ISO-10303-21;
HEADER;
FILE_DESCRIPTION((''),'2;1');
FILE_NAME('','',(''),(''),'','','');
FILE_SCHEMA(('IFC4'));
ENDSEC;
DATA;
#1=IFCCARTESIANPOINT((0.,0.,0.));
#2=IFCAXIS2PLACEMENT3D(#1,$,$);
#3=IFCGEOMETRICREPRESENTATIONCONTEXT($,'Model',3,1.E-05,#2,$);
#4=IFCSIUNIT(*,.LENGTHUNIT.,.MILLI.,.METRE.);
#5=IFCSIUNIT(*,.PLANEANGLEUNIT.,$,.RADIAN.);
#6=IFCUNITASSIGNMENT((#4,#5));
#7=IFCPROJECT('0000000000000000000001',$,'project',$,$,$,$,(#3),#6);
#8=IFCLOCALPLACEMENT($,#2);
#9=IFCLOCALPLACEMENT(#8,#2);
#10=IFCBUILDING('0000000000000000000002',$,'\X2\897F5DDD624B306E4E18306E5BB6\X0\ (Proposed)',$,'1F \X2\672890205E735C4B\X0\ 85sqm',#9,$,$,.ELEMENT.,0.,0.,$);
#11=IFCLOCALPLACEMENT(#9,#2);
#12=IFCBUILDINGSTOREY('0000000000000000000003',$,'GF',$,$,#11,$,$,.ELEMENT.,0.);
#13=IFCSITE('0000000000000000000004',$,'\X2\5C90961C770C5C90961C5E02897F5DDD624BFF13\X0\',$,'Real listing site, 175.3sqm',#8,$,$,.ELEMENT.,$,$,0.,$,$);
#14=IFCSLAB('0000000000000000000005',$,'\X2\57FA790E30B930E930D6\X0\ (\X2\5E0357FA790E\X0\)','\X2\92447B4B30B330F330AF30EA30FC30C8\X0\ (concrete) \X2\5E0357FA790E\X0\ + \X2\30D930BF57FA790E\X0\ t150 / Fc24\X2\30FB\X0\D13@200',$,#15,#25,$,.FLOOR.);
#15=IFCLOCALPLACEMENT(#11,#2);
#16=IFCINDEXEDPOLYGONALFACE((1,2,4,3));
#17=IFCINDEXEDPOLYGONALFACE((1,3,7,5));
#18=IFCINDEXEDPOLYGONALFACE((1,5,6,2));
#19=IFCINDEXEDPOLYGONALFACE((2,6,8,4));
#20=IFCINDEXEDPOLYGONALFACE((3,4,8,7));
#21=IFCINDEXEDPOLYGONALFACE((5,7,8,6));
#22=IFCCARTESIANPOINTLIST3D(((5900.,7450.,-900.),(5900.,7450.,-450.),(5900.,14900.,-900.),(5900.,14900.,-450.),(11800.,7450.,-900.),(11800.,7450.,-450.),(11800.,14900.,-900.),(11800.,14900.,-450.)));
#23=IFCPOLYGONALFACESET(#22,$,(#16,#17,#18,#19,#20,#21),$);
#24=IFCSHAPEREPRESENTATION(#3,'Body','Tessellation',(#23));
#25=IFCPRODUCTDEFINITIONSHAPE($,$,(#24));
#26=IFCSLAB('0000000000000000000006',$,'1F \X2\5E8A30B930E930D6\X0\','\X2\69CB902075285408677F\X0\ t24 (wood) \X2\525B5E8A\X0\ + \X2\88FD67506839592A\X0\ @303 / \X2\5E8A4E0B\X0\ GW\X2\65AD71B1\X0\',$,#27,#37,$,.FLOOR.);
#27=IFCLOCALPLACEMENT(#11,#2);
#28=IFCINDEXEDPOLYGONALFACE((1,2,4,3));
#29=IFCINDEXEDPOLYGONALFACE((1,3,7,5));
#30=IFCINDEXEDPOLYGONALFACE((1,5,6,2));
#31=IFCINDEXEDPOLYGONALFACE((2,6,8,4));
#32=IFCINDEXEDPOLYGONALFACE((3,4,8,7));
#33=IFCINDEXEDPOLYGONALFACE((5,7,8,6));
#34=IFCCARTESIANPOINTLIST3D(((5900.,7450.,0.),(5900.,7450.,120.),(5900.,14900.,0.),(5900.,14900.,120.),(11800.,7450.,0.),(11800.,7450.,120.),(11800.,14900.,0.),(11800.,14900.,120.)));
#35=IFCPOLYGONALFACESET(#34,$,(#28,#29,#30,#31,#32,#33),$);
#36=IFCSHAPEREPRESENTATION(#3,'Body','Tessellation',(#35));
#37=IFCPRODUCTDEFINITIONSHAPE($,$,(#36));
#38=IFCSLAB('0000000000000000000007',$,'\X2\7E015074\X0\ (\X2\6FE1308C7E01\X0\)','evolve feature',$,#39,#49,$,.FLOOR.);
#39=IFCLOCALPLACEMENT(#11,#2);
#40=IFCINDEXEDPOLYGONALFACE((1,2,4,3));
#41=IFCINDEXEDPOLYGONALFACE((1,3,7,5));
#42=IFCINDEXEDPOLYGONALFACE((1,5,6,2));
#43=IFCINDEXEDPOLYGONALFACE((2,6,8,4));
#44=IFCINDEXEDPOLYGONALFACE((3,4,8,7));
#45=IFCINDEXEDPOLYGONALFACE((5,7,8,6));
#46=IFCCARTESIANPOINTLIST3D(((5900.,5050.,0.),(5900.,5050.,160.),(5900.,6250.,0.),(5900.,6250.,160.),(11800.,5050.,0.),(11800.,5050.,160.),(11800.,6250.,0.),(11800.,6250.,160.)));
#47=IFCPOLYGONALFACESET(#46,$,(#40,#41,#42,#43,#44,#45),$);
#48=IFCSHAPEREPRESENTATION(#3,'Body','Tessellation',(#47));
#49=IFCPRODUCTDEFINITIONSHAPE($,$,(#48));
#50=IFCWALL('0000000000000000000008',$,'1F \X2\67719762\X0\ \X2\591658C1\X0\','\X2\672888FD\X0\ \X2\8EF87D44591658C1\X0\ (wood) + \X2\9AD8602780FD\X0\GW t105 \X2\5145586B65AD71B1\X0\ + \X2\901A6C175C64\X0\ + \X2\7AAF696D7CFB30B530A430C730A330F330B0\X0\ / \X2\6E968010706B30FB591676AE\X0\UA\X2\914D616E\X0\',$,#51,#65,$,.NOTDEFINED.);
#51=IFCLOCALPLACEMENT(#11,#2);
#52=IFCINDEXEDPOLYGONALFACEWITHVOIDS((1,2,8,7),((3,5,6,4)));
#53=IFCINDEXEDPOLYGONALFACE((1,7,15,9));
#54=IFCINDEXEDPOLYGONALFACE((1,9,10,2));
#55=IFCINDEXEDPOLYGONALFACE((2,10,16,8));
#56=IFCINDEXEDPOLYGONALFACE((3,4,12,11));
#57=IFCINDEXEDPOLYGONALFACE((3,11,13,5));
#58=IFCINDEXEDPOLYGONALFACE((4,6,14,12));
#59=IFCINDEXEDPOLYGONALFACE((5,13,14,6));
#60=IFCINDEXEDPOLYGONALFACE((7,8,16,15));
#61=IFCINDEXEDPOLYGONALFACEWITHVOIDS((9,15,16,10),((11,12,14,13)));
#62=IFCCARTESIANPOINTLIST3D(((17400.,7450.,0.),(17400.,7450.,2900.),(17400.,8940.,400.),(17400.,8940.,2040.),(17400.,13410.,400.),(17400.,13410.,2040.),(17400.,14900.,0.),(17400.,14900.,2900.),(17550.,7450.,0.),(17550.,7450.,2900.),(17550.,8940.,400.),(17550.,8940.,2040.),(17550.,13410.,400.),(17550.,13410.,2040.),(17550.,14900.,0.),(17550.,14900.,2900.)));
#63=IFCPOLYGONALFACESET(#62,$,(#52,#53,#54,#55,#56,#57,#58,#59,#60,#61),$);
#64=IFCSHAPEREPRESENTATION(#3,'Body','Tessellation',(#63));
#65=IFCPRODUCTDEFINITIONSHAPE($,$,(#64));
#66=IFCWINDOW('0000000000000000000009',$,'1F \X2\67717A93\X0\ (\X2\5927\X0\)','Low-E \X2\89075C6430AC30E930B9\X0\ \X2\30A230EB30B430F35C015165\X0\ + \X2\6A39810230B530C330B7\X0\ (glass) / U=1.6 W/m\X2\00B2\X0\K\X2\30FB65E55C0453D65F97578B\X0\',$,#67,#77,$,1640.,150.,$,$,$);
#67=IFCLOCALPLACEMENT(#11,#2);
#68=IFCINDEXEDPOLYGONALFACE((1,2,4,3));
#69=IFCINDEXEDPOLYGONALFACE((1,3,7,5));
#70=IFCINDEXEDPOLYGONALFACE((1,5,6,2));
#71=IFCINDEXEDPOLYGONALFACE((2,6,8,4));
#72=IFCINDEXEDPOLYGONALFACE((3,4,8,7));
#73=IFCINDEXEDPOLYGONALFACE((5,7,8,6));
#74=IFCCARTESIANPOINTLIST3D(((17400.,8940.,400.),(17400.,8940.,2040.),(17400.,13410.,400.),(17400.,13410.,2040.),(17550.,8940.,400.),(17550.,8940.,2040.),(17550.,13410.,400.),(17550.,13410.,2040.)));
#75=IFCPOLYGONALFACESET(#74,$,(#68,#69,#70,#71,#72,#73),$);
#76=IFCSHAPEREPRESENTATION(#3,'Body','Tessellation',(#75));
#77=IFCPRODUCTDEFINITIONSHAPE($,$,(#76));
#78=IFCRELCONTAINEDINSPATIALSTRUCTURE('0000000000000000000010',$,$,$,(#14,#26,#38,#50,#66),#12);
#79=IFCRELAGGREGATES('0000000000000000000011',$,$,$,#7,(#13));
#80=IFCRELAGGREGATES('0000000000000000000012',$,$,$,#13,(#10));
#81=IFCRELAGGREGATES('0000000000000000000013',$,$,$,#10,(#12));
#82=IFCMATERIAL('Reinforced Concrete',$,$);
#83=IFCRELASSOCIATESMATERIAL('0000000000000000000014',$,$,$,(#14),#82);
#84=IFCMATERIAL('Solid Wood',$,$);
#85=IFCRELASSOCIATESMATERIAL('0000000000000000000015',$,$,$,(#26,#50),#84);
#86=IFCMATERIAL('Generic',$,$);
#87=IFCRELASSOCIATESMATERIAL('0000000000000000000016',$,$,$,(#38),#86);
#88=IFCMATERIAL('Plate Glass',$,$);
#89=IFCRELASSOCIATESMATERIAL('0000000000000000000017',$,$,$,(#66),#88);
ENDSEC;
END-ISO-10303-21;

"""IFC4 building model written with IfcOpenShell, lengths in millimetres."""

from ifc_helpers import new_model, si_unit, frame, frame_2d, origin, place, context, project, spatial, rectangle, extrude, material, element, fill, save


model = new_model("IFC4")

# Units and contexts
model_context = context("Model", 3, precision=1e-05, world=origin())
ifc_project = project(units=[si_unit("LENGTHUNIT", "METRE", prefix="MILLI"), si_unit("PLANEANGLEUNIT", "RADIAN")], contexts=[model_context])

# Site, building, storey
site_placement = place(None, origin())
site = spatial("IfcSite", under=ifc_project, at=site_placement, Name="岐阜県岐阜市西川手３", ObjectType="Real listing site, 175.3sqm", CompositionType="ELEMENT", RefElevation=0.0)
building_placement = place(site_placement, origin())
building = spatial("IfcBuilding", under=site, at=building_placement, Name="西川手の丘の家 (Proposed)", ObjectType="1F 木造平屋 85sqm", CompositionType="ELEMENT", ElevationOfRefHeight=0.0, ElevationOfTerrain=0.0)
storey_placement = place(building_placement, origin())
storey = spatial("IfcBuildingStorey", under=building, at=storey_placement, Name="GF", CompositionType="ELEMENT", Elevation=0.0)

# Slabs
ifc_material_1 = material(Name="Reinforced Concrete")
slab_1_placement = place(storey_placement, frame((2950.0, 3725.0, -450.0)))
element("IfcSlab", 1, at=slab_1_placement, inside=storey, material=ifc_material_1, Name="基礎スラブ (布基礎)", Description="鉄筋コンクリート (concrete) 布基礎 + ベタ基礎 t150 / Fc24・D13@200", PredefinedType="FLOOR", context=model_context, shape_type="SweptSolid", body=[
    extrude(rectangle(XDim=5900.0, YDim=7450.0, at=frame_2d((2950.0, 3725.0))), frame((2950.0, 3725.0, -450.0)), (0.0, 0.0, 1.0), 450.0),
])
ifc_material_2 = material(Name="Solid Wood")
slab_2_placement = place(storey_placement, frame((2950.0, 3725.0, 0.0)))
element("IfcSlab", 2, at=slab_2_placement, inside=storey, material=ifc_material_2, Name="1F 床スラブ", Description="構造用合板 t24 (wood) 剛床 + 製材根太 @303 / 床下 GW断熱", PredefinedType="FLOOR", context=model_context, shape_type="SweptSolid", body=[
    extrude(rectangle(XDim=5900.0, YDim=7450.0, at=frame_2d((2950.0, 3725.0))), frame((2950.0, 3725.0, 0.0)), (0.0, 0.0, 1.0), 120.0),
])
ifc_material_3 = material(Name="Generic")
slab_3_placement = place(storey_placement, frame((2950.0, 2525.0, 0.0)))
element("IfcSlab", 3, at=slab_3_placement, inside=storey, material=ifc_material_3, Name="縁側 (濡れ縁)", Description="evolve feature", PredefinedType="FLOOR", context=model_context, shape_type="SweptSolid", body=[
    extrude(rectangle(XDim=5900.0, YDim=1200.0, at=frame_2d((2950.0, 600.0))), frame((2950.0, 2525.0, 0.0)), (0.0, 0.0, 1.0), 160.0),
])

# Shared definitions
ifc_material_4 = material(Name="Plate Glass")

# Wall, opening, window
wall_1_placement = place(storey_placement, frame((8700.0, 3725.0, 0.0)))
wall_1 = element("IfcWall", 4, at=wall_1_placement, inside=storey, material=ifc_material_2, Name="1F 東面 外壁", Description="木製 軸組外壁 (wood) + 高性能GW t105 充填断熱 + 通気層 + 窯業系サイディング / 準耐火・外皮UA配慮", PredefinedType="NOTDEFINED", context=model_context, shape_type="SweptSolid", body=[
    extrude(rectangle(XDim=150.0, YDim=7450.0, at=frame_2d((75.0, 3725.0))), frame((8700.0, 3725.0, 0.0)), (0.0, 0.0, 1.0), 2900.0),
])
opening_1_placement = place(storey_placement, frame((8700.0, 4470.0, 200.0)))
opening_1 = element("IfcOpeningElement", 5, at=opening_1_placement, cuts=wall_1, PredefinedType="NOTDEFINED", context=model_context, shape_type="SweptSolid", body=[
    extrude(rectangle(XDim=150.0, YDim=4470.0, at=frame_2d((75.0, 2235.0))), frame((8700.0, 4470.0, 200.0)), (0.0, 0.0, 1.0), 1640.0),
])
window_1_placement = place(storey_placement, frame((8700.0, 4470.0, 200.0)))
window_1 = element("IfcWindow", 6, at=window_1_placement, inside=storey, material=ifc_material_4, Name="1F 東窓 (大)", Description="Low-E 複層ガラス アルゴン封入 + 樹脂サッシ (glass) / U=1.6 W/m²K・日射取得型", OverallHeight=1640.0, OverallWidth=150.0, context=model_context, shape_type="SweptSolid", body=[
    extrude(rectangle(XDim=150.0, YDim=4470.0, at=frame_2d((75.0, 2235.0))), frame((8700.0, 4470.0, 200.0)), (0.0, 0.0, 1.0), 1640.0),
])
fill(opening_1, window_1)

save(model, "model.ifc")
